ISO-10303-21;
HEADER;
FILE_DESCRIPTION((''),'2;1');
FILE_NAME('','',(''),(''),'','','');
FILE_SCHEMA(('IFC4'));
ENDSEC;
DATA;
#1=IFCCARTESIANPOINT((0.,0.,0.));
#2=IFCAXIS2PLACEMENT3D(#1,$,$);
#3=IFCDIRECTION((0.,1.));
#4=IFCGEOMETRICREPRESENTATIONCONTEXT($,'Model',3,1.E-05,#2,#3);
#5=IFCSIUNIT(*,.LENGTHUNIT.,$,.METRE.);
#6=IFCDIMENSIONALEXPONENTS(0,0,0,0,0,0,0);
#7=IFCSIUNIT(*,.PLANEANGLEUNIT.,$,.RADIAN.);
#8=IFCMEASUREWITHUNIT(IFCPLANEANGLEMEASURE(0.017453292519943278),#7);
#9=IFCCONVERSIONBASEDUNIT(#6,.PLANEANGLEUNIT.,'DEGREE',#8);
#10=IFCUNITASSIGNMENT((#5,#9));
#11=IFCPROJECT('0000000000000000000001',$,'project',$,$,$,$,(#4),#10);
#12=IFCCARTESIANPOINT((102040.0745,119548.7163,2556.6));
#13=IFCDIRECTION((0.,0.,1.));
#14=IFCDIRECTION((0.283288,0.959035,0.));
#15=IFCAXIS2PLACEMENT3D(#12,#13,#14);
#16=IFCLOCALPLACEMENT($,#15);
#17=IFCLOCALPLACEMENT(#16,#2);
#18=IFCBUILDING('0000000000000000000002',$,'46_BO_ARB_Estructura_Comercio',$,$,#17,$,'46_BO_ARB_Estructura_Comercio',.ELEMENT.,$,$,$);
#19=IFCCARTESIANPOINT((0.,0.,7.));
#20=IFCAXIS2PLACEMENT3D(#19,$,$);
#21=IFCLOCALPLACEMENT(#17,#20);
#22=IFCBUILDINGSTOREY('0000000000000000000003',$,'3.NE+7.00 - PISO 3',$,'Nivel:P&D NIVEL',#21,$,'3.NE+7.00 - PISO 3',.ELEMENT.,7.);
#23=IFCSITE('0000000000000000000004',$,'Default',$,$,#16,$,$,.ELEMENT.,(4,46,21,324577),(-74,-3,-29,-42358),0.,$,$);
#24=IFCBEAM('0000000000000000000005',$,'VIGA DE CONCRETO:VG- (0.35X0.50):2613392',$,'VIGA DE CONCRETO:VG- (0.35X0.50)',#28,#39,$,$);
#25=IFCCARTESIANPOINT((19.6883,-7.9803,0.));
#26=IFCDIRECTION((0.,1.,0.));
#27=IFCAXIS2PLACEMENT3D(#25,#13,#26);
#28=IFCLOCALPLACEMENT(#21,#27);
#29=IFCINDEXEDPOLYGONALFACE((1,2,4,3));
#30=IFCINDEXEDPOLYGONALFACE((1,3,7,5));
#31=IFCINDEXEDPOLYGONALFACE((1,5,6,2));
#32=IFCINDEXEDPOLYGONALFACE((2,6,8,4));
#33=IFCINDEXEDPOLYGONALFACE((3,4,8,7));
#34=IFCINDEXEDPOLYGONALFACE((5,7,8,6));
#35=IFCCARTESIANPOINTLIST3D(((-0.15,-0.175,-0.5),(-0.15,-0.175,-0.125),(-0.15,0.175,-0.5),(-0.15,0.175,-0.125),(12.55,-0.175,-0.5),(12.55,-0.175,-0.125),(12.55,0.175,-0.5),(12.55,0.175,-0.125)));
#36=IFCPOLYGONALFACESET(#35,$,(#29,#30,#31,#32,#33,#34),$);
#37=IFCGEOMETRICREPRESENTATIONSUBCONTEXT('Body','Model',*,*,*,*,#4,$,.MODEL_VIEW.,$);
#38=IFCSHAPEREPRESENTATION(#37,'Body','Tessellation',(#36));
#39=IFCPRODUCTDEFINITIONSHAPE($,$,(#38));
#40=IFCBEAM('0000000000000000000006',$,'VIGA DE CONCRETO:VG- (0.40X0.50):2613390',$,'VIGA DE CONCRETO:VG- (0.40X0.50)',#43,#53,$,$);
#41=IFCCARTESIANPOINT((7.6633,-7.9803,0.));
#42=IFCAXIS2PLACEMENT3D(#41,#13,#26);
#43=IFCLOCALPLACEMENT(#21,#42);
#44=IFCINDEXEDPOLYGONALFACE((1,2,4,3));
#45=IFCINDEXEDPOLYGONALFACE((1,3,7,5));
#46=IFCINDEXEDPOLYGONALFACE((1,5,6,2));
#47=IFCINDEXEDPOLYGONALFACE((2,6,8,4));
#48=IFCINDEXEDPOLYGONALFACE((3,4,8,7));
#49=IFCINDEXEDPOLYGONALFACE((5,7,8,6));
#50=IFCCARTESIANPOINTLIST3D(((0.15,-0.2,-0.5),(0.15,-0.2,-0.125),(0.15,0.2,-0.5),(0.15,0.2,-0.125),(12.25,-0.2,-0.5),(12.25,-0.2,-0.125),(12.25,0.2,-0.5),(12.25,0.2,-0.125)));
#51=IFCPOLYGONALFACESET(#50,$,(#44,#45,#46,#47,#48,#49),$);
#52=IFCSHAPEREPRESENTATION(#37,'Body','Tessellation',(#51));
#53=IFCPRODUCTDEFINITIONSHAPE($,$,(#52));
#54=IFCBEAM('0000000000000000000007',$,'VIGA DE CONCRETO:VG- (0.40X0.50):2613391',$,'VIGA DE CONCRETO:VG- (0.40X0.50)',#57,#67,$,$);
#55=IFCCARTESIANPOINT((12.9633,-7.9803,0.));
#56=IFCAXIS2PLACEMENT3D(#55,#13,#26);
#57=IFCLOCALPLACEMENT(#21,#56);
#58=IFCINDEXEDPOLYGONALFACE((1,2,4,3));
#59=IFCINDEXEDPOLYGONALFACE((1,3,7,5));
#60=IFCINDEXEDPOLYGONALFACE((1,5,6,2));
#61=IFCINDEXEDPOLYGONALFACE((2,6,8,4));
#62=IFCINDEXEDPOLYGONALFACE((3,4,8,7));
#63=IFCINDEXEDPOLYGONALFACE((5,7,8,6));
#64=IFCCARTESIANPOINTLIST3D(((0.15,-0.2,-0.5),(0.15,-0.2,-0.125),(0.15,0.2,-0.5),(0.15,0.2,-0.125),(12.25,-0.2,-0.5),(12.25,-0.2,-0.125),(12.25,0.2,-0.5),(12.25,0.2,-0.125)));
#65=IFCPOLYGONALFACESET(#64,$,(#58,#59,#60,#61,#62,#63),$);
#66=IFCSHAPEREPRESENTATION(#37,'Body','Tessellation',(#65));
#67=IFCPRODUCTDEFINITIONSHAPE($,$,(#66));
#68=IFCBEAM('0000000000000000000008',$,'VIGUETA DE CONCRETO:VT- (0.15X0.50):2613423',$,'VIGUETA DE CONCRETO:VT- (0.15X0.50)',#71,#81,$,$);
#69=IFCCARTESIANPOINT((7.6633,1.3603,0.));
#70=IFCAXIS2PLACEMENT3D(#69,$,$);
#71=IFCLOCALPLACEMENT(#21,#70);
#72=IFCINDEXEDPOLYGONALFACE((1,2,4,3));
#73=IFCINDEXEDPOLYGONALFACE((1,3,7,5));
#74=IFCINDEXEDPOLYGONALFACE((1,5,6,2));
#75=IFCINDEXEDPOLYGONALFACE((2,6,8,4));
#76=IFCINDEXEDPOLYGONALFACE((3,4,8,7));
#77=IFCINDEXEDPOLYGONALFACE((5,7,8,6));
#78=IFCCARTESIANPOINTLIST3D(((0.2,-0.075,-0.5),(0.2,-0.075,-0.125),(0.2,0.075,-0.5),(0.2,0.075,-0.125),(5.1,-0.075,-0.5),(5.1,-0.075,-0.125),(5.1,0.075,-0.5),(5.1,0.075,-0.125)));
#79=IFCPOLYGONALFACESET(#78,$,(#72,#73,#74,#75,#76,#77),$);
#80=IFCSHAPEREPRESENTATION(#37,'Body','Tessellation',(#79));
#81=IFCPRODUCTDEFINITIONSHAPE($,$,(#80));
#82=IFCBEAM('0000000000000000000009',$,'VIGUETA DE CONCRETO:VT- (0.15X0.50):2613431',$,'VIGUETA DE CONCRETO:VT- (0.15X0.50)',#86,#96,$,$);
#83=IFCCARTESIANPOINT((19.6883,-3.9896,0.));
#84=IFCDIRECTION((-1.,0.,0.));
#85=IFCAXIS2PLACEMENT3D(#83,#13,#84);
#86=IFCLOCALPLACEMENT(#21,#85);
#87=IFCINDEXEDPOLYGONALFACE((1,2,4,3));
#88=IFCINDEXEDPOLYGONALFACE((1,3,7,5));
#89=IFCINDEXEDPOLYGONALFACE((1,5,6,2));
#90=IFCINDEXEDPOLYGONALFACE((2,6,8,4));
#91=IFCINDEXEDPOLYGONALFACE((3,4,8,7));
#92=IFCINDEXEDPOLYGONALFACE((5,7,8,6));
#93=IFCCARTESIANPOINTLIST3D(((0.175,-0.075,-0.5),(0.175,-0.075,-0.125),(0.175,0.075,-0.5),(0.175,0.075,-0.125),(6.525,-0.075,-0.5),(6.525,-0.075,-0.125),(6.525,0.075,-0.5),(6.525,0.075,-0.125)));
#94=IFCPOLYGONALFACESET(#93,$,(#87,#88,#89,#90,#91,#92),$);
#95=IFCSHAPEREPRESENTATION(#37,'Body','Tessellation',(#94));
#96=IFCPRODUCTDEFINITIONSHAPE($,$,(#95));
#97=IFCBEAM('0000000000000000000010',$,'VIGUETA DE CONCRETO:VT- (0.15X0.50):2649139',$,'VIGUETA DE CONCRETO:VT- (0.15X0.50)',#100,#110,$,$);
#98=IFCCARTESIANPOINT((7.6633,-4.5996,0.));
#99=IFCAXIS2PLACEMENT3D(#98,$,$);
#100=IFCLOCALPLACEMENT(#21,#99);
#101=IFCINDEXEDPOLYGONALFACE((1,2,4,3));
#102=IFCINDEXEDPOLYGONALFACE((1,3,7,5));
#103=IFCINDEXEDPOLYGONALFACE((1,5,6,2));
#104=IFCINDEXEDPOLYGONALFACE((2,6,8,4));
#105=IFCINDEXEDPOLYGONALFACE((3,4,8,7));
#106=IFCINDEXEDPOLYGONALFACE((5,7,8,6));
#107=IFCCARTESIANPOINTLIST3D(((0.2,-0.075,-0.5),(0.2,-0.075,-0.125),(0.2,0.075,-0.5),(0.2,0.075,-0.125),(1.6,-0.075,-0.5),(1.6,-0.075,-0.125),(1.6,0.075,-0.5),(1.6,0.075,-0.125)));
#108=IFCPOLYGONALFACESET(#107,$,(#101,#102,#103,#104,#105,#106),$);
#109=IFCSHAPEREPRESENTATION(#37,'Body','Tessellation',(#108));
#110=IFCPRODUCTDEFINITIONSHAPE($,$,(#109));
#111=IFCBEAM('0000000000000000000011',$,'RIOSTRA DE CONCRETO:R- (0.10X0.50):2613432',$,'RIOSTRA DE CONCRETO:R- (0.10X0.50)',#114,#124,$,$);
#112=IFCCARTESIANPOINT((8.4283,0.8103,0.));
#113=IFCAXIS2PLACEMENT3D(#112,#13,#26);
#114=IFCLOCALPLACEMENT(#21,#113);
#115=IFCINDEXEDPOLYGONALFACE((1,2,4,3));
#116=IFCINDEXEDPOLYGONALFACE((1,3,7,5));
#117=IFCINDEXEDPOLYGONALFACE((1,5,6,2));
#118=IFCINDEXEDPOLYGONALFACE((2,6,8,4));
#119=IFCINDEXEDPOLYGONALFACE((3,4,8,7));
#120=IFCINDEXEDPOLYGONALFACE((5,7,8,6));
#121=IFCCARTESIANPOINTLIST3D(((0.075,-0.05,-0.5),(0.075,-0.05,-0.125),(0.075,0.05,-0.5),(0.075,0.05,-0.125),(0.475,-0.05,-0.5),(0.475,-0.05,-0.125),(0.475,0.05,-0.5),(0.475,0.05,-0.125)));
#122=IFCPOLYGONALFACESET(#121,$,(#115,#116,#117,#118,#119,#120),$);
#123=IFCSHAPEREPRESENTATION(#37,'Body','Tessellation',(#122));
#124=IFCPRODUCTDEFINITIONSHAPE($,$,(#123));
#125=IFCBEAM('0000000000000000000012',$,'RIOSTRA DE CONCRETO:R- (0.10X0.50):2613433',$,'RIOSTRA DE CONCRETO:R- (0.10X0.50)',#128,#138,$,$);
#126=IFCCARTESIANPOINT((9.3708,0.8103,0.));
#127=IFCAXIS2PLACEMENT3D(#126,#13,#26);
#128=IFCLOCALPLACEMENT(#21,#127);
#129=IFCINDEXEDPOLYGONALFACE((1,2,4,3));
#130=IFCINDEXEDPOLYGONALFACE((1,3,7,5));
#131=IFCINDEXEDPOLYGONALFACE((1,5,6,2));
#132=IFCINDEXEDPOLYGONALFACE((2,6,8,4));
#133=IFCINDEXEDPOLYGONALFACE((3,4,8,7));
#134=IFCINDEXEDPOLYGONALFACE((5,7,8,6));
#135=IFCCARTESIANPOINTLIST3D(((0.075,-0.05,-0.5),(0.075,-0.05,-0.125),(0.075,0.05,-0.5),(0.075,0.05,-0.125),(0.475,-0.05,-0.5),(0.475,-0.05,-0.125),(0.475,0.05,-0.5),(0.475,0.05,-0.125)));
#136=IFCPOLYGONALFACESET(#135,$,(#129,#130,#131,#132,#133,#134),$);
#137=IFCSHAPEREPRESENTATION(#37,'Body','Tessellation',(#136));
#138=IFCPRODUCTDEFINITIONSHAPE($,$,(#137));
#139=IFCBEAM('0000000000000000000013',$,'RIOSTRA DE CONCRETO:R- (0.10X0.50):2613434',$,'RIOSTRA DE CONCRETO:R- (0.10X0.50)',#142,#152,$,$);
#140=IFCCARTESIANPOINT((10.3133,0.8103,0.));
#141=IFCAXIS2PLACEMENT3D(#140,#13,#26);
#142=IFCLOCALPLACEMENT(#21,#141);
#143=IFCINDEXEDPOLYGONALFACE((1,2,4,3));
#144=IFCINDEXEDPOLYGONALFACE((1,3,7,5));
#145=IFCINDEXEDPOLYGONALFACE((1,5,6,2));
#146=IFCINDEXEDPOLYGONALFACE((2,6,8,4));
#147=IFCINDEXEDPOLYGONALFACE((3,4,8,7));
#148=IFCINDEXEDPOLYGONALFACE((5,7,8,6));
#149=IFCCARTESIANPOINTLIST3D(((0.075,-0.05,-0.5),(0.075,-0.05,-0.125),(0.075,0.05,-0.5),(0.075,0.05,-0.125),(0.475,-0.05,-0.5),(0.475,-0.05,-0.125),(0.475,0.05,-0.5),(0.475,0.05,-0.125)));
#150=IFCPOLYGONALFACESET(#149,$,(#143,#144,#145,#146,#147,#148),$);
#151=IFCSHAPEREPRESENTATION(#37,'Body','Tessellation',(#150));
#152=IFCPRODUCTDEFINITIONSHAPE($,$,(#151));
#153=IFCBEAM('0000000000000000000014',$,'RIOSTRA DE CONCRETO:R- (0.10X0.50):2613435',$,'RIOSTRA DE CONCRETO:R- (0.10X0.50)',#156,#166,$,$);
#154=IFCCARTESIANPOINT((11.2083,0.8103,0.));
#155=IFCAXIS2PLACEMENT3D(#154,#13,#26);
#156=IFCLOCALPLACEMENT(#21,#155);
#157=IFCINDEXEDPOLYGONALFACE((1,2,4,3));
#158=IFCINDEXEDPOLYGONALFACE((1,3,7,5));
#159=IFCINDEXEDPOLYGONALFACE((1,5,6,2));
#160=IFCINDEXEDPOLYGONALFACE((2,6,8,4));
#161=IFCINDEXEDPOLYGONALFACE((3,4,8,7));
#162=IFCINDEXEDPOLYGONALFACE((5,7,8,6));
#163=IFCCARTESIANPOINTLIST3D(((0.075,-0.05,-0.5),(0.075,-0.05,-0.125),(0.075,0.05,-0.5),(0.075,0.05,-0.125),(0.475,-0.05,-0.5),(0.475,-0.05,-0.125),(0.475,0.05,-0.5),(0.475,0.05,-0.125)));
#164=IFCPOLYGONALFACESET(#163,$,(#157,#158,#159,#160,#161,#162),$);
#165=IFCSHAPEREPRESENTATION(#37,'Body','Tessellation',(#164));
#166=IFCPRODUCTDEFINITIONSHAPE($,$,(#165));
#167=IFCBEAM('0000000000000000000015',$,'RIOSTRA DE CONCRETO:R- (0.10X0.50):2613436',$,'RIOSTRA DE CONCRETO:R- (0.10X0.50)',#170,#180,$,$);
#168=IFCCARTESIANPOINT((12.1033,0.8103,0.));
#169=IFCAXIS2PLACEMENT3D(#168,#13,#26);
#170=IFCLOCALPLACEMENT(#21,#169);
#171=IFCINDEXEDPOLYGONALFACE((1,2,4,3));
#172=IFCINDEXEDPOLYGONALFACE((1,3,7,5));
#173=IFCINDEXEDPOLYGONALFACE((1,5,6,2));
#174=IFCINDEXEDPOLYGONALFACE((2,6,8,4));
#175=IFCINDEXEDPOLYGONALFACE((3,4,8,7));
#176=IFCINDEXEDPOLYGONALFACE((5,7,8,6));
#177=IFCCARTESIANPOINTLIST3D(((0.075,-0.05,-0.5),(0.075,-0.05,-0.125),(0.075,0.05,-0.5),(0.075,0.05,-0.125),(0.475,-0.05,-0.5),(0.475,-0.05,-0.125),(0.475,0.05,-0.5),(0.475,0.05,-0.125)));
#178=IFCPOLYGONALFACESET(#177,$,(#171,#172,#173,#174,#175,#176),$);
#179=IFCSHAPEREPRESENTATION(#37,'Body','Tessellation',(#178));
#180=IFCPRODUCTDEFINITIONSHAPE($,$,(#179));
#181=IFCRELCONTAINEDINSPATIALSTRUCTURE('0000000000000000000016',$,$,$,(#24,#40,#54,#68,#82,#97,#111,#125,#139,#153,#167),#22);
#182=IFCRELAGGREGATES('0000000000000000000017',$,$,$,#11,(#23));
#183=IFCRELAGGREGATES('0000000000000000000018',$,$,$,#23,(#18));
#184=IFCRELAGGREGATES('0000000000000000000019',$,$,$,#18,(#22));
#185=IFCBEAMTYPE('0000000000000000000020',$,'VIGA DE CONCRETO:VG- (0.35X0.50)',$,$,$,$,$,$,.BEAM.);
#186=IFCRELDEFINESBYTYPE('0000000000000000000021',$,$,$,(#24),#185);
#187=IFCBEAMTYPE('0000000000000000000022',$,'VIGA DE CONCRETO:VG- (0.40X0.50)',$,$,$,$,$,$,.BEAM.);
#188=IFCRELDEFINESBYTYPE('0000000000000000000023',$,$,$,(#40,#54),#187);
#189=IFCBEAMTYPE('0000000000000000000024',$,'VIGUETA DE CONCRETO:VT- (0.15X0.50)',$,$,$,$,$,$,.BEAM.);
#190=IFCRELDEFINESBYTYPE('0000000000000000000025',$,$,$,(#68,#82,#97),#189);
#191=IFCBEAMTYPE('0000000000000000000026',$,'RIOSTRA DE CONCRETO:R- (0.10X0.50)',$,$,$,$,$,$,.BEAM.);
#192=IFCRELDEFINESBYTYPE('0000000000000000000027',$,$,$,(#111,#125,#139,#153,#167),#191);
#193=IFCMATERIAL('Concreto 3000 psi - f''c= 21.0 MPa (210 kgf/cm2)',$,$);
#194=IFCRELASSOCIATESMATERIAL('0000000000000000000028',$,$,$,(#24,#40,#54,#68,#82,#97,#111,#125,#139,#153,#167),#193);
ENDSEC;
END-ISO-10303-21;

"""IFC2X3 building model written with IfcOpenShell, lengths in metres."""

from ifc_helpers import new_model, entity, si_unit, converted_unit, direction, frame, frame_2d, origin, origin_2d_with_axis, place, context, subcontext, project, spatial, rectangle, extrude, material, type_object, element, save


model = new_model("IFC2X3")

# Units and contexts
model_context = context("Model", 3, precision=1e-05, world=origin(), true_north=direction((0.0, 1.0)))
body_context = subcontext(model_context, "Body", "Model", "MODEL_VIEW")
ifc_project = project(units=[si_unit("LENGTHUNIT", "METRE"), converted_unit("PLANEANGLEUNIT", "DEGREE", entity("IfcPlaneAngleMeasure", 0.017453292519943278), si_unit("PLANEANGLEUNIT", "RADIAN"), dimensions=[0, 0, 0, 0, 0, 0, 0])], contexts=[model_context])

# Site, building, storey
site_placement = place(None, frame((102040.0745, 119548.7163, 2556.6), z_axis=(0.0, 0.0, 1.0), x_axis=(0.283288, 0.959035, 0.0)))
site = spatial("IfcSite", under=ifc_project, at=site_placement, Name="Default", CompositionType="ELEMENT", RefLatitude=(4, 46, 21, 324577), RefLongitude=(-74, -3, -29, -42358), RefElevation=0.0)
building_placement = place(site_placement, origin())
building = spatial("IfcBuilding", under=site, at=building_placement, Name="46_BO_ARB_Estructura_Comercio", LongName="46_BO_ARB_Estructura_Comercio", CompositionType="ELEMENT")
storey_placement = place(building_placement, frame((0.0, 0.0, 7.0)))
storey = spatial("IfcBuildingStorey", under=building, at=storey_placement, Name="3.NE+7.00 - PISO 3", ObjectType="Nivel:P&D NIVEL", LongName="3.NE+7.00 - PISO 3", CompositionType="ELEMENT", Elevation=7.0)

# Beams
ifc_material = material(Name="Concreto 3000 psi - f'c= 21.0 MPa (210 kgf/cm2)")
beam_type_1 = type_object("IfcBeamType", Name="VIGA DE CONCRETO:VG- (0.35X0.50)", PredefinedType="BEAM")
beam_1_placement = place(storey_placement, frame((19.6883, -7.9803, 0.0), z_axis=(0.0, 0.0, 1.0), x_axis=(0.0, 1.0, 0.0)))
element("IfcBeam", 1, at=beam_1_placement, inside=storey, type_object=beam_type_1, material=ifc_material, Name="VIGA DE CONCRETO:VG- (0.35X0.50):2613392", ObjectType="VIGA DE CONCRETO:VG- (0.35X0.50)", context=body_context, shape_type="SweptSolid", body=[
    extrude(rectangle(XDim=0.375, YDim=0.35, at=frame_2d((0.0, 0.0), x_axis=(1.0, 0.0))), frame((-0.15, 0.0, -0.3125), z_axis=(1.0, 0.0, 0.0), x_axis=(0.0, 0.0, -1.0)), (0.0, 0.0, 1.0), 12.7),
])
beam_type_2 = type_object("IfcBeamType", Name="VIGA DE CONCRETO:VG- (0.40X0.50)", PredefinedType="BEAM")
beam_2_placement = place(storey_placement, frame((7.6633, -7.9803, 0.0), z_axis=(0.0, 0.0, 1.0), x_axis=(0.0, 1.0, 0.0)))
element("IfcBeam", 2, at=beam_2_placement, inside=storey, type_object=beam_type_2, material=ifc_material, Name="VIGA DE CONCRETO:VG- (0.40X0.50):2613390", ObjectType="VIGA DE CONCRETO:VG- (0.40X0.50)", context=body_context, shape_type="SweptSolid", body=[
    extrude(rectangle(XDim=0.375, YDim=0.4, at=origin_2d_with_axis()), frame((0.15, 0.0, -0.3125), z_axis=(1.0, 0.0, 0.0), x_axis=(0.0, 0.0, -1.0)), (0.0, 0.0, 1.0), 12.1),
])
beam_3_placement = place(storey_placement, frame((12.9633, -7.9803, 0.0), z_axis=(0.0, 0.0, 1.0), x_axis=(0.0, 1.0, 0.0)))
element("IfcBeam", 3, at=beam_3_placement, inside=storey, type_object=beam_type_2, material=ifc_material, Name="VIGA DE CONCRETO:VG- (0.40X0.50):2613391", ObjectType="VIGA DE CONCRETO:VG- (0.40X0.50)", context=body_context, shape_type="SweptSolid", body=[
    extrude(rectangle(XDim=0.375, YDim=0.4, at=frame_2d((0.0, 0.0), x_axis=(1.0, 0.0))), frame((0.15, 0.0, -0.3125), z_axis=(1.0, 0.0, 0.0), x_axis=(0.0, 0.0, -1.0)), (0.0, 0.0, 1.0), 12.1),
])
beam_type_3 = type_object("IfcBeamType", Name="VIGUETA DE CONCRETO:VT- (0.15X0.50)", PredefinedType="BEAM")
beam_4_placement = place(storey_placement, frame((7.6633, 1.3603, 0.0)))
element("IfcBeam", 4, at=beam_4_placement, inside=storey, type_object=beam_type_3, material=ifc_material, Name="VIGUETA DE CONCRETO:VT- (0.15X0.50):2613423", ObjectType="VIGUETA DE CONCRETO:VT- (0.15X0.50)", context=body_context, shape_type="SweptSolid", body=[
    extrude(rectangle(XDim=0.375, YDim=0.15, at=frame_2d((0.0, 0.0), x_axis=(1.0, 0.0))), frame((0.2, 0.0, -0.3125), z_axis=(1.0, 0.0, 0.0), x_axis=(0.0, 0.0, -1.0)), (0.0, 0.0, 1.0), 4.9),
])
beam_5_placement = place(storey_placement, frame((19.6883, -3.9896, 0.0), z_axis=(0.0, 0.0, 1.0), x_axis=(-1.0, 0.0, 0.0)))
element("IfcBeam", 5, at=beam_5_placement, inside=storey, type_object=beam_type_3, material=ifc_material, Name="VIGUETA DE CONCRETO:VT- (0.15X0.50):2613431", ObjectType="VIGUETA DE CONCRETO:VT- (0.15X0.50)", context=body_context, shape_type="SweptSolid", body=[
    extrude(rectangle(XDim=0.375, YDim=0.15, at=frame_2d((0.0, 0.0), x_axis=(1.0, 0.0))), frame((0.175, 0.0, -0.3125), z_axis=(1.0, 0.0, 0.0), x_axis=(0.0, 0.0, -1.0)), (0.0, 0.0, 1.0), 6.35),
])
beam_6_placement = place(storey_placement, frame((7.6633, -4.5996, 0.0)))
element("IfcBeam", 6, at=beam_6_placement, inside=storey, type_object=beam_type_3, material=ifc_material, Name="VIGUETA DE CONCRETO:VT- (0.15X0.50):2649139", ObjectType="VIGUETA DE CONCRETO:VT- (0.15X0.50)", context=body_context, shape_type="SweptSolid", body=[
    extrude(rectangle(XDim=0.375, YDim=0.15, at=frame_2d((0.0, 0.0), x_axis=(1.0, 0.0))), frame((0.2, 0.0, -0.3125), z_axis=(1.0, 0.0, 0.0), x_axis=(0.0, 0.0, -1.0)), (0.0, 0.0, 1.0), 1.4),
])
beam_type_4 = type_object("IfcBeamType", Name="RIOSTRA DE CONCRETO:R- (0.10X0.50)", PredefinedType="BEAM")
beam_7_placement = place(storey_placement, frame((8.4283, 0.8103, 0.0), z_axis=(0.0, 0.0, 1.0), x_axis=(0.0, 1.0, 0.0)))
element("IfcBeam", 7, at=beam_7_placement, inside=storey, type_object=beam_type_4, material=ifc_material, Name="RIOSTRA DE CONCRETO:R- (0.10X0.50):2613432", ObjectType="RIOSTRA DE CONCRETO:R- (0.10X0.50)", context=body_context, shape_type="SweptSolid", body=[
    extrude(rectangle(XDim=0.375, YDim=0.1, at=frame_2d((0.0, 0.0), x_axis=(1.0, 0.0))), frame((0.075, 0.0, -0.3125), z_axis=(1.0, 0.0, 0.0), x_axis=(0.0, 0.0, -1.0)), (0.0, 0.0, 1.0), 0.4),
])
beam_8_placement = place(storey_placement, frame((9.3708, 0.8103, 0.0), z_axis=(0.0, 0.0, 1.0), x_axis=(0.0, 1.0, 0.0)))
element("IfcBeam", 8, at=beam_8_placement, inside=storey, type_object=beam_type_4, material=ifc_material, Name="RIOSTRA DE CONCRETO:R- (0.10X0.50):2613433", ObjectType="RIOSTRA DE CONCRETO:R- (0.10X0.50)", context=body_context, shape_type="SweptSolid", body=[
    extrude(rectangle(XDim=0.375, YDim=0.1, at=frame_2d((0.0, 0.0), x_axis=(1.0, 0.0))), frame((0.075, 0.0, -0.3125), z_axis=(1.0, 0.0, 0.0), x_axis=(0.0, 0.0, -1.0)), (0.0, 0.0, 1.0), 0.4),
])
beam_9_placement = place(storey_placement, frame((10.3133, 0.8103, 0.0), z_axis=(0.0, 0.0, 1.0), x_axis=(0.0, 1.0, 0.0)))
element("IfcBeam", 9, at=beam_9_placement, inside=storey, type_object=beam_type_4, material=ifc_material, Name="RIOSTRA DE CONCRETO:R- (0.10X0.50):2613434", ObjectType="RIOSTRA DE CONCRETO:R- (0.10X0.50)", context=body_context, shape_type="SweptSolid", body=[
    extrude(rectangle(XDim=0.375, YDim=0.1, at=origin_2d_with_axis()), frame((0.075, 0.0, -0.3125), z_axis=(1.0, 0.0, 0.0), x_axis=(0.0, 0.0, -1.0)), (0.0, 0.0, 1.0), 0.4),
])
beam_10_placement = place(storey_placement, frame((11.2083, 0.8103, 0.0), z_axis=(0.0, 0.0, 1.0), x_axis=(0.0, 1.0, 0.0)))
element("IfcBeam", 10, at=beam_10_placement, inside=storey, type_object=beam_type_4, material=ifc_material, Name="RIOSTRA DE CONCRETO:R- (0.10X0.50):2613435", ObjectType="RIOSTRA DE CONCRETO:R- (0.10X0.50)", context=body_context, shape_type="SweptSolid", body=[
    extrude(rectangle(XDim=0.375, YDim=0.1, at=origin_2d_with_axis()), frame((0.075, 0.0, -0.3125), z_axis=(1.0, 0.0, 0.0), x_axis=(0.0, 0.0, -1.0)), (0.0, 0.0, 1.0), 0.4),
])
beam_11_placement = place(storey_placement, frame((12.1033, 0.8103, 0.0), z_axis=(0.0, 0.0, 1.0), x_axis=(0.0, 1.0, 0.0)))
element("IfcBeam", 11, at=beam_11_placement, inside=storey, type_object=beam_type_4, material=ifc_material, Name="RIOSTRA DE CONCRETO:R- (0.10X0.50):2613436", ObjectType="RIOSTRA DE CONCRETO:R- (0.10X0.50)", context=body_context, shape_type="SweptSolid", body=[
    extrude(rectangle(XDim=0.375, YDim=0.1, at=origin_2d_with_axis()), frame((0.075, 0.0, -0.3125), z_axis=(1.0, 0.0, 0.0), x_axis=(0.0, 0.0, -1.0)), (0.0, 0.0, 1.0), 0.4),
])

save(model, "model.ifc")
